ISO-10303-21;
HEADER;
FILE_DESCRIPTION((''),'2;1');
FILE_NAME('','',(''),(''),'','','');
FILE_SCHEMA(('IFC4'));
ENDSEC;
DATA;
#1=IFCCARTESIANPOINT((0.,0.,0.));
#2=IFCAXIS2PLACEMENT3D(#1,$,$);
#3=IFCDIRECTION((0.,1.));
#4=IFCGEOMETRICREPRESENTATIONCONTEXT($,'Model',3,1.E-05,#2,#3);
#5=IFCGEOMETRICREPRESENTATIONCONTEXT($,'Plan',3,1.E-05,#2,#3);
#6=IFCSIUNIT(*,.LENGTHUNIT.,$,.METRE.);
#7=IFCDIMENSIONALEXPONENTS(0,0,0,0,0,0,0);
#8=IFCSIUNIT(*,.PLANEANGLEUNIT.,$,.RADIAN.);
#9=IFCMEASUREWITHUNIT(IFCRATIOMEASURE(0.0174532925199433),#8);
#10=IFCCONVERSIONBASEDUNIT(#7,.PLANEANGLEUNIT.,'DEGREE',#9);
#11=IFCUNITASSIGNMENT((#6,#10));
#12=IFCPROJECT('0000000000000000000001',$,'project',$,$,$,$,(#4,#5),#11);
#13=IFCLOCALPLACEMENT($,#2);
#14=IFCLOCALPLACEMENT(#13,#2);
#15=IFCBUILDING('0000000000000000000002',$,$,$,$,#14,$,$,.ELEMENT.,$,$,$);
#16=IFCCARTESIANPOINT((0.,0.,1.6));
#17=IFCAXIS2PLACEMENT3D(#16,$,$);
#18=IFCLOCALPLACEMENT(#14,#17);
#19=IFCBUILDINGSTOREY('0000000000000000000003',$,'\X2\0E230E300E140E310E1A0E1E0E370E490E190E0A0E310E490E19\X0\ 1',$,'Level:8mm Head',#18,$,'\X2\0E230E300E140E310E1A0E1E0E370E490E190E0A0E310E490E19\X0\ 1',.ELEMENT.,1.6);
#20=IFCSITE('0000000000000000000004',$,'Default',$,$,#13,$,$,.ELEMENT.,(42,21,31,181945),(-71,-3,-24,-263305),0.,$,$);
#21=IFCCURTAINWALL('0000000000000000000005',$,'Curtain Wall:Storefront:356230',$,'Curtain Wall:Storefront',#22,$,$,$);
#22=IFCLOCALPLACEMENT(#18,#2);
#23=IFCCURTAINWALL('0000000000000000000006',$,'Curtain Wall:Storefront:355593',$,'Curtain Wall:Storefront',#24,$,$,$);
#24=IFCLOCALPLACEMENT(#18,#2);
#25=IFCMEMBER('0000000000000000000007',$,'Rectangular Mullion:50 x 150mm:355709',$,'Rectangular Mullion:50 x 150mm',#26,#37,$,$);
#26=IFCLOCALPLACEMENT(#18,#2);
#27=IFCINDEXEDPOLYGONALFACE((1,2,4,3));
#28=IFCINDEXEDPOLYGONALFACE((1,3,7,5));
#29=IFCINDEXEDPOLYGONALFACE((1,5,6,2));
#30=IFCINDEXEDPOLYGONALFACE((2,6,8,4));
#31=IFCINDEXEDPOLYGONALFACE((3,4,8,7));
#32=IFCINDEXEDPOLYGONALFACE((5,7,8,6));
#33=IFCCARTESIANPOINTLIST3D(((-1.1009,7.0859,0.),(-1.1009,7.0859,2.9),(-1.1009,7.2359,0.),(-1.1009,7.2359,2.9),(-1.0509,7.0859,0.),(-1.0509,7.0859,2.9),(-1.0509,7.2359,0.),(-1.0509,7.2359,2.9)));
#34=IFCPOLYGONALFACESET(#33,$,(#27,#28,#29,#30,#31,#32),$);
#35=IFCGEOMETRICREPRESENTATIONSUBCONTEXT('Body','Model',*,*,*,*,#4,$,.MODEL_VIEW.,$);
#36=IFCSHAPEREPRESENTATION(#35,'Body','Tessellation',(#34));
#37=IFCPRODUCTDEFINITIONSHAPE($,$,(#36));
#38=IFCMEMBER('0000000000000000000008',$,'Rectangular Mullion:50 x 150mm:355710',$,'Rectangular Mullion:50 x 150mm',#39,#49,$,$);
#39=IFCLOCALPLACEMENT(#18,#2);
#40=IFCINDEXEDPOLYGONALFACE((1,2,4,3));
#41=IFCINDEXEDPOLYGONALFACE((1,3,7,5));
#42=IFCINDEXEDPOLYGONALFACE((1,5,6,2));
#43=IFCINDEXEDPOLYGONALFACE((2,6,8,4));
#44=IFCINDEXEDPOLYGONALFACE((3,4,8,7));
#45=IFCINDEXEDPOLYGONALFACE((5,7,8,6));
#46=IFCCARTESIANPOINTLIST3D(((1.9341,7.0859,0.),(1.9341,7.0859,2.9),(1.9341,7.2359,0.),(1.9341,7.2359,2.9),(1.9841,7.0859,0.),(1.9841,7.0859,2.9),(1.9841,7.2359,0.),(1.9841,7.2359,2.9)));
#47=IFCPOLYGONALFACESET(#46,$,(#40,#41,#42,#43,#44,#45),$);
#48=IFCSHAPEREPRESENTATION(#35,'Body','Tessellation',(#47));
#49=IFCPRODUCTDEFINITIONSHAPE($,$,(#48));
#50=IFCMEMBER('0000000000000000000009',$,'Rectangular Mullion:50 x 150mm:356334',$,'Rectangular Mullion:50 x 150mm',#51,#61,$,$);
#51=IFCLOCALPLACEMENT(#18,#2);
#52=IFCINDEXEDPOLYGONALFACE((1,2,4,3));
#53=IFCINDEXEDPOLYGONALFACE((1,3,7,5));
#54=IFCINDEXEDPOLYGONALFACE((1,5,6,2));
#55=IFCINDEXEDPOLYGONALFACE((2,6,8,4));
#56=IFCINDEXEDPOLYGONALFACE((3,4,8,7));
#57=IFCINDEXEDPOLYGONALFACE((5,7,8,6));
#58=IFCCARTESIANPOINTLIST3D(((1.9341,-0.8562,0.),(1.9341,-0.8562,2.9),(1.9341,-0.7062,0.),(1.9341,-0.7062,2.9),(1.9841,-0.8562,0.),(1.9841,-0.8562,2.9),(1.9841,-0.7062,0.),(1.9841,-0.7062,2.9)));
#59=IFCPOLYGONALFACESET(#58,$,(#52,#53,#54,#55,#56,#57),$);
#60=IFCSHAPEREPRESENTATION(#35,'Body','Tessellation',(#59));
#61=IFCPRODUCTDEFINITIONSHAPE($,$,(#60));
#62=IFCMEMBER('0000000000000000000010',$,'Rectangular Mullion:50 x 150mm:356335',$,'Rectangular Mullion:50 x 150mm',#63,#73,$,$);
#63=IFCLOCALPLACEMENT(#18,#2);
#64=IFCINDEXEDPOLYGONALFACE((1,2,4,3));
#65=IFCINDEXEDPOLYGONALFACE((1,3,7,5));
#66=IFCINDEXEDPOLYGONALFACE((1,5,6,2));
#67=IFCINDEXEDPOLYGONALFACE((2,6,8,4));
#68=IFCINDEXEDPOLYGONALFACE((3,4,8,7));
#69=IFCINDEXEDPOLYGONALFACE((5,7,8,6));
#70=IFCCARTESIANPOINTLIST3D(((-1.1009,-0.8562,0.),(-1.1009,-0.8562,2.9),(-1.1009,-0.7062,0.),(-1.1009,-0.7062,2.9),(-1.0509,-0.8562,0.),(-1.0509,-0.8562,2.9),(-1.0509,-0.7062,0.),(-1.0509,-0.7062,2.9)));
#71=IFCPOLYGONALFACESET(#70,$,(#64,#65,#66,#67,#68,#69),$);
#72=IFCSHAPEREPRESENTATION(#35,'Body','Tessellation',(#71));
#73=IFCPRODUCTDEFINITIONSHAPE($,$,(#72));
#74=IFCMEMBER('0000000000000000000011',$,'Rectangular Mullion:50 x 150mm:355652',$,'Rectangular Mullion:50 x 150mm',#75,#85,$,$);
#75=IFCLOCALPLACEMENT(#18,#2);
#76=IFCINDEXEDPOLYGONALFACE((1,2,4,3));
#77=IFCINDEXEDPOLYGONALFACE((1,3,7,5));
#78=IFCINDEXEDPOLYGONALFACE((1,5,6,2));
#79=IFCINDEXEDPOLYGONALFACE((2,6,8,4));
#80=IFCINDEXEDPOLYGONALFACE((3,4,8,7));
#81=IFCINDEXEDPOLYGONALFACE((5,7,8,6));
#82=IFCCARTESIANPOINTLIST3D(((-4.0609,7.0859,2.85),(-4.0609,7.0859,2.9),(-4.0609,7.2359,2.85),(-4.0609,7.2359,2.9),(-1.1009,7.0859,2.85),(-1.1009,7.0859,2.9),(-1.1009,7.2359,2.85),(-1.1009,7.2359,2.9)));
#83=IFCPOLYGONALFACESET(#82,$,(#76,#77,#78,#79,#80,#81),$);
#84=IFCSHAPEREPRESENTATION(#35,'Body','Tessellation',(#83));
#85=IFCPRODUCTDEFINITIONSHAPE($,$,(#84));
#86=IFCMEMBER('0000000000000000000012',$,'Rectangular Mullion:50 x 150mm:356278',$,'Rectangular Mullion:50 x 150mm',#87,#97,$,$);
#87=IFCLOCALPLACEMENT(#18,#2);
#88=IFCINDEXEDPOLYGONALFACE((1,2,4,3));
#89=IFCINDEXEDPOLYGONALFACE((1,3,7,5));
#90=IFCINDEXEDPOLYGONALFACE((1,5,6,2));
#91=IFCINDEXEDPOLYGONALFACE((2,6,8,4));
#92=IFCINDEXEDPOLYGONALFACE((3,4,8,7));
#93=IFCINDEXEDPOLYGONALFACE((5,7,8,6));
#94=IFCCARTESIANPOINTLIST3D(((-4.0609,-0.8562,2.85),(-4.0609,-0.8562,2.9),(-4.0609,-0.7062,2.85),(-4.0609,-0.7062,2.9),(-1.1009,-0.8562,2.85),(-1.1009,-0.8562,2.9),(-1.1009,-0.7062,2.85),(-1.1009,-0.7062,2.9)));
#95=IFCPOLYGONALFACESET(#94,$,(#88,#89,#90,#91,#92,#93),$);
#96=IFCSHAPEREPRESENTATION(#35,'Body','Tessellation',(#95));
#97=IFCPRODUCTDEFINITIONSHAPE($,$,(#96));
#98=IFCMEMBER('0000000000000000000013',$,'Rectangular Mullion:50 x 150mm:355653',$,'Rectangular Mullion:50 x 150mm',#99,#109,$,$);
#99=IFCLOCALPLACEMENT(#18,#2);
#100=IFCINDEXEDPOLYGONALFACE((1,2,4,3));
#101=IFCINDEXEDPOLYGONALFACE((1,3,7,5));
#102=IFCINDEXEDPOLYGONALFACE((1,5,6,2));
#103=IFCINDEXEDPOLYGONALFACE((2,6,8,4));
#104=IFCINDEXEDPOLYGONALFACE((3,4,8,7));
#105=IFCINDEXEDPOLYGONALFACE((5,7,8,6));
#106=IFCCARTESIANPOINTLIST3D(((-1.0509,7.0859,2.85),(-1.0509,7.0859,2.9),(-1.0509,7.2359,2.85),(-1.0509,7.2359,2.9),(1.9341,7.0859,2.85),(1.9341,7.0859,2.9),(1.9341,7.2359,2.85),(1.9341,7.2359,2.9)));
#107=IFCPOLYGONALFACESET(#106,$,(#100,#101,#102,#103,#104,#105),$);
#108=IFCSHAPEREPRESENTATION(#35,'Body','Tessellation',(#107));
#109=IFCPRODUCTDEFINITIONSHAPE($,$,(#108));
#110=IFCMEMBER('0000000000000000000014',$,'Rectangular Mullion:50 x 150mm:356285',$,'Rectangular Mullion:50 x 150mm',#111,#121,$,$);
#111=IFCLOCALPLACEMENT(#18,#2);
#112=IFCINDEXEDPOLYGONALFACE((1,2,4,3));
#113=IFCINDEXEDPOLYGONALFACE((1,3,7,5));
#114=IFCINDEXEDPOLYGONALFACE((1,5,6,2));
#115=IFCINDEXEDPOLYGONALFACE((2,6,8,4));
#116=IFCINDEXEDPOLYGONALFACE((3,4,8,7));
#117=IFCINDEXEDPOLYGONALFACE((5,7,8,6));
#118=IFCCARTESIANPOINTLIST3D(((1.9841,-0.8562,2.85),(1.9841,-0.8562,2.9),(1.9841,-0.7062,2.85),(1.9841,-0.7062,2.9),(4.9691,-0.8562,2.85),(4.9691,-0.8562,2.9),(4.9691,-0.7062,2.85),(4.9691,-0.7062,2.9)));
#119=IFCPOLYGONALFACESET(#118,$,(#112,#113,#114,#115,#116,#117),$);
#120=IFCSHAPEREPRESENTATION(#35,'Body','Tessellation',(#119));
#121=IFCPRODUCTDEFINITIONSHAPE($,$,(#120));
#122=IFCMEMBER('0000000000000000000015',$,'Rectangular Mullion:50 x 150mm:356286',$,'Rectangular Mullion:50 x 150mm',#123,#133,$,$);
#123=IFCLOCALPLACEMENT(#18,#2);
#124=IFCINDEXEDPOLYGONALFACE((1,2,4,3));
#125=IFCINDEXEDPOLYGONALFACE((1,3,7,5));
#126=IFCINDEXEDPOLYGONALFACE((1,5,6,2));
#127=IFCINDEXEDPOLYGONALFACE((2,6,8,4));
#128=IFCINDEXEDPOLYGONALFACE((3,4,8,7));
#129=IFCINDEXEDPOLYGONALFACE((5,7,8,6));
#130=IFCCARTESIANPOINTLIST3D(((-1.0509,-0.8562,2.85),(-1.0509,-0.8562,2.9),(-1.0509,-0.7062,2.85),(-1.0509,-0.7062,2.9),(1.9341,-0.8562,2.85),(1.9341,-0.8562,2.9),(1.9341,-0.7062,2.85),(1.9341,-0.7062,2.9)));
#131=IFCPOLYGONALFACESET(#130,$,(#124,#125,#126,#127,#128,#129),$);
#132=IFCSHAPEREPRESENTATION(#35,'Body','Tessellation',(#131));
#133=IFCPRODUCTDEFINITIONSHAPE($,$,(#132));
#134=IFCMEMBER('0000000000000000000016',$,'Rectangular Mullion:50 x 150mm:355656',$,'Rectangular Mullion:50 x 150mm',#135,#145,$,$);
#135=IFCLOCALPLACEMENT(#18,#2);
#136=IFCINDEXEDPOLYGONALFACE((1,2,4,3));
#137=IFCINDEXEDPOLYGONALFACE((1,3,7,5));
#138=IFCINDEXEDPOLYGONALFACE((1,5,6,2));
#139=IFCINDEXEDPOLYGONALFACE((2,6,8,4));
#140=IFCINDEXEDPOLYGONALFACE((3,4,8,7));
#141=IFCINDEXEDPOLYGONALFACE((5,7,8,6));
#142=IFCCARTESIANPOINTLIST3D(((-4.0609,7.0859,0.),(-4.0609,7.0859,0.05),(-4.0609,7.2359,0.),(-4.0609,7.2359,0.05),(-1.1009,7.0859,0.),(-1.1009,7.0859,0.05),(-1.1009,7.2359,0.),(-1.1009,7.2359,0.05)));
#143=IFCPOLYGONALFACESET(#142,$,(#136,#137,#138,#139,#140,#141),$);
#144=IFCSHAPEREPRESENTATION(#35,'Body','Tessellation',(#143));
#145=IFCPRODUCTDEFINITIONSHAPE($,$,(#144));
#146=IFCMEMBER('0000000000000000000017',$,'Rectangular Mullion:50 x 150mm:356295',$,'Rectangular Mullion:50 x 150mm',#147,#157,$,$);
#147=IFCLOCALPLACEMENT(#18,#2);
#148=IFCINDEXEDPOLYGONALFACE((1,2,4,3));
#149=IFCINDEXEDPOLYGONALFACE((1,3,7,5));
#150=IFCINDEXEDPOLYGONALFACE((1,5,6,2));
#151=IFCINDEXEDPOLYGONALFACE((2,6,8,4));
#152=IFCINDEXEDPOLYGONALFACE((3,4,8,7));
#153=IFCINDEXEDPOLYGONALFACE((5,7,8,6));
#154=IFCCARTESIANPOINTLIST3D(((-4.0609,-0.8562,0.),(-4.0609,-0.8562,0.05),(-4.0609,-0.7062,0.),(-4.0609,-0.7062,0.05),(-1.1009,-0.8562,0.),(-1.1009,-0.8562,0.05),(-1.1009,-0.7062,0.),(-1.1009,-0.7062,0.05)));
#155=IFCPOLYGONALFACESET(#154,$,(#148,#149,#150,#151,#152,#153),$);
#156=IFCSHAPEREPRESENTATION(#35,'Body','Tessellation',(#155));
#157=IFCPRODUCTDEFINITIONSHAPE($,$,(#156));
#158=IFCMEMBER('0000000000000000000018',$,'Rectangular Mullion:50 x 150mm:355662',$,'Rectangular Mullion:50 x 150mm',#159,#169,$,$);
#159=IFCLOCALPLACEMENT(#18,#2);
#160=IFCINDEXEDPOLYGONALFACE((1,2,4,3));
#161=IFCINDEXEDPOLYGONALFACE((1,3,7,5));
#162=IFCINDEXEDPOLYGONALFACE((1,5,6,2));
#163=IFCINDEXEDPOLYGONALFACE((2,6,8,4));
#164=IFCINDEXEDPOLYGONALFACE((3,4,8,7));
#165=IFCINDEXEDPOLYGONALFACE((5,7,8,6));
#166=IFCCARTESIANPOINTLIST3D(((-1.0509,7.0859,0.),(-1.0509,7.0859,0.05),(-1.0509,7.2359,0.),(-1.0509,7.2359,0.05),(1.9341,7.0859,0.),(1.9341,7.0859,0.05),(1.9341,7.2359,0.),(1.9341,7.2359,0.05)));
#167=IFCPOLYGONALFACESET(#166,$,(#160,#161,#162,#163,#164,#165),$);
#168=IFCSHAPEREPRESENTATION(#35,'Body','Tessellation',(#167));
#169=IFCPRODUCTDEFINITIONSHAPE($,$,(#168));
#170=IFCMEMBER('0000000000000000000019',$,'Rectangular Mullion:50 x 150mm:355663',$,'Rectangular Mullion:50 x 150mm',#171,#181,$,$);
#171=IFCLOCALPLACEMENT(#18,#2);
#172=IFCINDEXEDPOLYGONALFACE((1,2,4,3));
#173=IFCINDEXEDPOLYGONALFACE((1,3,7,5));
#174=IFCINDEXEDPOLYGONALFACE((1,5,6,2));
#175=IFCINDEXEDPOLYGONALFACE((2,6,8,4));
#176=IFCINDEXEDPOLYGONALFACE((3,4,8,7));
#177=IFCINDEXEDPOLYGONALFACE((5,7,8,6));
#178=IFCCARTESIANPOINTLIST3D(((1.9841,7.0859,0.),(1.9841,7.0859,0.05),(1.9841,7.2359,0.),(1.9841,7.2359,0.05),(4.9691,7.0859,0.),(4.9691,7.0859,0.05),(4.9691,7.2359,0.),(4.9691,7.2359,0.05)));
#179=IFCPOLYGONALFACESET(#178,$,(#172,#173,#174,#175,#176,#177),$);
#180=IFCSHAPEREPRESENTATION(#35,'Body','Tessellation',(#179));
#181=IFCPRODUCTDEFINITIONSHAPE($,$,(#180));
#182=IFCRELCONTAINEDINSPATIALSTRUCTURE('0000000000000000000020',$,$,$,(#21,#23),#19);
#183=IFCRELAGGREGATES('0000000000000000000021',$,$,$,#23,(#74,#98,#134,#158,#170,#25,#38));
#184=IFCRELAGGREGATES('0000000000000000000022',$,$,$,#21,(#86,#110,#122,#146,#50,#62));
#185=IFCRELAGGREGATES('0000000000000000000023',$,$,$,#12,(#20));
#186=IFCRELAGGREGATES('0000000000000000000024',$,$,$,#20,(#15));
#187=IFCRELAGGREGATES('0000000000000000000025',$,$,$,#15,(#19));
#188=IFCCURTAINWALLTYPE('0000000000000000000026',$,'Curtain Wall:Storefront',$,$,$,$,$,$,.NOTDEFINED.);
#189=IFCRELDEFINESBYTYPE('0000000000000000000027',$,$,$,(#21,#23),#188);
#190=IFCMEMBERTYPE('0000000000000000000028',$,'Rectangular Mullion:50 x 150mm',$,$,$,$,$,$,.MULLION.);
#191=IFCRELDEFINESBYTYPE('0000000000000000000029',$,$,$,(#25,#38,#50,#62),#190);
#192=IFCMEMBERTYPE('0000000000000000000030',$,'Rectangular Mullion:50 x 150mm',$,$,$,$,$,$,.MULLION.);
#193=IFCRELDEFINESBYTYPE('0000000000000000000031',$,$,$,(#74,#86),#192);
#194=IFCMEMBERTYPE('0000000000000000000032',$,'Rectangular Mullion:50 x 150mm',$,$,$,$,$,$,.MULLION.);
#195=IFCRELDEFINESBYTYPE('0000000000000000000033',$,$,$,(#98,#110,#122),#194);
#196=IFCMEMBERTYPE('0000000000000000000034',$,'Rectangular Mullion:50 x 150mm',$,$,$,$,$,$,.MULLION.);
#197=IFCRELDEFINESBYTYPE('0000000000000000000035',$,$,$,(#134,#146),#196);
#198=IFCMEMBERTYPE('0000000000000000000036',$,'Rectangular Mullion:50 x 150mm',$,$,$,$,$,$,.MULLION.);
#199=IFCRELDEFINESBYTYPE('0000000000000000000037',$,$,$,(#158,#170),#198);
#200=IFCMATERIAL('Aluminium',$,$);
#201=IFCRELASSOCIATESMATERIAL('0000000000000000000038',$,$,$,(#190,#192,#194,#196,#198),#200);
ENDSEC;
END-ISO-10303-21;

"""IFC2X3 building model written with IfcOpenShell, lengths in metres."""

from ifc_helpers import new_model, entity, si_unit, converted_unit, direction, frame, origin, origin_2d_with_axis, place, context, subcontext, project, spatial, rectangle, extrude, source, transform, mapped, material, type_object, type_shapes, element, aggregate, save


model = new_model("IFC2X3")

# Units and contexts
model_context = context("Model", 3, precision=1e-05, world=origin(), true_north=direction((0.0, 1.0)))
plan_context = context("Plan", 3, precision=1e-05, world=origin(), true_north=direction((0.0, 1.0)))
body_context = subcontext(model_context, "Body", "Model", "MODEL_VIEW")
ifc_project = project(units=[si_unit("LENGTHUNIT", "METRE"), converted_unit("PLANEANGLEUNIT", "DEGREE", entity("IfcRatioMeasure", 0.0174532925199433), si_unit("PLANEANGLEUNIT", "RADIAN"), dimensions=[0, 0, 0, 0, 0, 0, 0])], contexts=[model_context, plan_context])

# Site, building, storey
site_placement = place(None, origin())
site = spatial("IfcSite", under=ifc_project, at=site_placement, Name="Default", CompositionType="ELEMENT", RefLatitude=(42, 21, 31, 181945), RefLongitude=(-71, -3, -24, -263305), RefElevation=0.0)
building_placement = place(site_placement, origin())
building = spatial("IfcBuilding", under=site, at=building_placement, CompositionType="ELEMENT")
storey_placement = place(building_placement, frame((0.0, 0.0, 1.6)))
storey = spatial("IfcBuildingStorey", under=building, at=storey_placement, Name="ระดับพื้นชั้น 1", ObjectType="Level:8mm Head", LongName="ระดับพื้นชั้น 1", CompositionType="ELEMENT", Elevation=1.6)

# Shared definitions
curtain_wall_type = type_object("IfcCurtainWallType", Name="Curtain Wall:Storefront", PredefinedType="NOTDEFINED")
ifc_material_1 = material(Name="Aluminium")

# Curtain wall
curtain_wall_1_placement = place(storey_placement, frame((0.0, 0.0, -1.6)))
curtain_wall_1 = element("IfcCurtainWall", 1, at=curtain_wall_1_placement, inside=storey, type_object=curtain_wall_type, Name="Curtain Wall:Storefront:356230", ObjectType="Curtain Wall:Storefront")

# Curtain wall
curtain_wall_2_placement = place(storey_placement, frame((0.0, 0.0, -1.6)))
curtain_wall_2 = element("IfcCurtainWall", 2, at=curtain_wall_2_placement, inside=storey, type_object=curtain_wall_type, Name="Curtain Wall:Storefront:355593", ObjectType="Curtain Wall:Storefront")

# Members
member_type_1 = type_object("IfcMemberType", Name="Rectangular Mullion:50 x 150mm", PredefinedType="MULLION", material=ifc_material_1)
shared_shape_1 = source(origin(), body_context, "Body", "SweptSolid", [
    extrude(rectangle(XDim=0.15, YDim=0.05, at=origin_2d_with_axis()), frame((0.0, 0.0, -2.9), z_axis=(0.0, 0.0, 1.0), x_axis=(0.0, -1.0, 0.0)), (0.0, 0.0, 1.0), 2.9),
])
type_shapes(member_type_1, [shared_shape_1])
member_1_placement = place(curtain_wall_2_placement, frame((-1.0759, 7.1609, 1.6), z_axis=(0.0, 0.0, -1.0), x_axis=(1.0, 0.0, 0.0)))
member_1 = element("IfcMember", 3, at=member_1_placement, type_object=member_type_1, Name="Rectangular Mullion:50 x 150mm:355709", ObjectType="Rectangular Mullion:50 x 150mm", context=body_context, shape_type="MappedRepresentation", body=[
    mapped(shared_shape_1, transform((0.0, 0.0, 0.0), scale=1.0)),
])
member_2_placement = place(curtain_wall_2_placement, frame((1.9591, 7.1609, 1.6), z_axis=(0.0, 0.0, -1.0), x_axis=(1.0, 0.0, 0.0)))
member_2 = element("IfcMember", 4, at=member_2_placement, type_object=member_type_1, Name="Rectangular Mullion:50 x 150mm:355710", ObjectType="Rectangular Mullion:50 x 150mm", context=body_context, shape_type="MappedRepresentation", body=[
    mapped(shared_shape_1, transform((0.0, 0.0, 0.0), scale=1.0)),
])
member_3_placement = place(curtain_wall_1_placement, frame((1.9591, -0.7812, 1.6), z_axis=(0.0, 0.0, -1.0), x_axis=(-1.0, 0.0, 0.0)))
member_3 = element("IfcMember", 5, at=member_3_placement, type_object=member_type_1, Name="Rectangular Mullion:50 x 150mm:356334", ObjectType="Rectangular Mullion:50 x 150mm", context=body_context, shape_type="MappedRepresentation", body=[
    mapped(shared_shape_1, transform((0.0, 0.0, 0.0), scale=1.0)),
])
member_4_placement = place(curtain_wall_1_placement, frame((-1.0759, -0.7812, 1.6), z_axis=(0.0, 0.0, -1.0), x_axis=(-1.0, 0.0, 0.0)))
member_4 = element("IfcMember", 6, at=member_4_placement, type_object=member_type_1, Name="Rectangular Mullion:50 x 150mm:356335", ObjectType="Rectangular Mullion:50 x 150mm", context=body_context, shape_type="MappedRepresentation", body=[
    mapped(shared_shape_1, transform((0.0, 0.0, 0.0), scale=1.0)),
])
member_type_2 = type_object("IfcMemberType", Name="Rectangular Mullion:50 x 150mm", PredefinedType="MULLION", material=ifc_material_1)
shared_shape_2 = source(origin(), body_context, "Body", "SweptSolid", [
    extrude(rectangle(XDim=0.15, YDim=0.05, at=origin_2d_with_axis()), frame((-0.025, 0.0, -2.96), z_axis=(0.0, 0.0, 1.0), x_axis=(0.0, -1.0, 0.0)), (0.0, 0.0, 1.0), 2.96),
])
type_shapes(member_type_2, [shared_shape_2])
member_5_placement = place(curtain_wall_2_placement, frame((-1.1009, 7.1609, 4.5), z_axis=(1.0, 0.0, 0.0), x_axis=(0.0, 0.0, 1.0)))
member_5 = element("IfcMember", 7, at=member_5_placement, type_object=member_type_2, Name="Rectangular Mullion:50 x 150mm:355652", ObjectType="Rectangular Mullion:50 x 150mm", context=body_context, shape_type="MappedRepresentation", body=[
    mapped(shared_shape_2, transform((0.0, 0.0, 0.0), scale=1.0)),
])
member_6_placement = place(curtain_wall_1_placement, frame((-4.0609, -0.7812, 4.5), z_axis=(-1.0, 0.0, 0.0), x_axis=(0.0, 0.0, 1.0)))
member_6 = element("IfcMember", 8, at=member_6_placement, type_object=member_type_2, Name="Rectangular Mullion:50 x 150mm:356278", ObjectType="Rectangular Mullion:50 x 150mm", context=body_context, shape_type="MappedRepresentation", body=[
    mapped(shared_shape_2, transform((0.0, 0.0, 0.0), scale=1.0)),
])
member_type_3 = type_object("IfcMemberType", Name="Rectangular Mullion:50 x 150mm", PredefinedType="MULLION", material=ifc_material_1)
shared_shape_3 = source(origin(), body_context, "Body", "SweptSolid", [
    extrude(rectangle(XDim=0.15, YDim=0.05, at=origin_2d_with_axis()), frame((-0.025, 0.0, -2.985), z_axis=(0.0, 0.0, 1.0), x_axis=(0.0, -1.0, 0.0)), (0.0, 0.0, 1.0), 2.985),
])
type_shapes(member_type_3, [shared_shape_3])
member_7_placement = place(curtain_wall_2_placement, frame((1.9341, 7.1609, 4.5), z_axis=(1.0, 0.0, 0.0), x_axis=(0.0, 0.0, 1.0)))
member_7 = element("IfcMember", 9, at=member_7_placement, type_object=member_type_3, Name="Rectangular Mullion:50 x 150mm:355653", ObjectType="Rectangular Mullion:50 x 150mm", context=body_context, shape_type="MappedRepresentation", body=[
    mapped(shared_shape_3, transform((0.0, 0.0, 0.0), scale=1.0)),
])
member_8_placement = place(curtain_wall_1_placement, frame((1.9841, -0.7812, 4.5), z_axis=(-1.0, 0.0, 0.0), x_axis=(0.0, 0.0, 1.0)))
member_8 = element("IfcMember", 10, at=member_8_placement, type_object=member_type_3, Name="Rectangular Mullion:50 x 150mm:356285", ObjectType="Rectangular Mullion:50 x 150mm", context=body_context, shape_type="MappedRepresentation", body=[
    mapped(shared_shape_3, transform((0.0, 0.0, 0.0), scale=1.0)),
])
member_9_placement = place(curtain_wall_1_placement, frame((-1.0509, -0.7812, 4.5), z_axis=(-1.0, 0.0, 0.0), x_axis=(0.0, 0.0, 1.0)))
member_9 = element("IfcMember", 11, at=member_9_placement, type_object=member_type_3, Name="Rectangular Mullion:50 x 150mm:356286", ObjectType="Rectangular Mullion:50 x 150mm", context=body_context, shape_type="MappedRepresentation", body=[
    mapped(shared_shape_3, transform((0.0, 0.0, 0.0), scale=1.0)),
])
member_type_4 = type_object("IfcMemberType", Name="Rectangular Mullion:50 x 150mm", PredefinedType="MULLION", material=ifc_material_1)
shared_shape_4 = source(origin(), body_context, "Body", "SweptSolid", [
    extrude(rectangle(XDim=0.15, YDim=0.05, at=origin_2d_with_axis()), frame((-0.025, 0.0, -2.96), z_axis=(0.0, 0.0, 1.0), x_axis=(0.0, -1.0, 0.0)), (0.0, 0.0, 1.0), 2.96),
])
type_shapes(member_type_4, [shared_shape_4])
member_10_placement = place(curtain_wall_2_placement, frame((-4.0609, 7.1609, 1.6), z_axis=(-1.0, 0.0, 0.0), x_axis=(0.0, 0.0, -1.0)))
member_10 = element("IfcMember", 12, at=member_10_placement, type_object=member_type_4, Name="Rectangular Mullion:50 x 150mm:355656", ObjectType="Rectangular Mullion:50 x 150mm", context=body_context, shape_type="MappedRepresentation", body=[
    mapped(shared_shape_4, transform((0.0, 0.0, 0.0), scale=1.0)),
])
member_11_placement = place(curtain_wall_1_placement, frame((-1.1009, -0.7812, 1.6), z_axis=(1.0, 0.0, 0.0), x_axis=(0.0, 0.0, -1.0)))
member_11 = element("IfcMember", 13, at=member_11_placement, type_object=member_type_4, Name="Rectangular Mullion:50 x 150mm:356295", ObjectType="Rectangular Mullion:50 x 150mm", context=body_context, shape_type="MappedRepresentation", body=[
    mapped(shared_shape_4, transform((0.0, 0.0, 0.0), scale=1.0)),
])
member_type_5 = type_object("IfcMemberType", Name="Rectangular Mullion:50 x 150mm", PredefinedType="MULLION", material=ifc_material_1)
shared_shape_5 = source(origin(), body_context, "Body", "SweptSolid", [
    extrude(rectangle(XDim=0.15, YDim=0.05, at=origin_2d_with_axis()), frame((-0.025, 0.0, -2.985), z_axis=(0.0, 0.0, 1.0), x_axis=(0.0, -1.0, 0.0)), (0.0, 0.0, 1.0), 2.985),
])
type_shapes(member_type_5, [shared_shape_5])
member_12_placement = place(curtain_wall_2_placement, frame((-1.0509, 7.1609, 1.6), z_axis=(-1.0, 0.0, 0.0), x_axis=(0.0, 0.0, -1.0)))
member_12 = element("IfcMember", 14, at=member_12_placement, type_object=member_type_5, Name="Rectangular Mullion:50 x 150mm:355662", ObjectType="Rectangular Mullion:50 x 150mm", context=body_context, shape_type="MappedRepresentation", body=[
    mapped(shared_shape_5, transform((0.0, 0.0, 0.0), scale=1.0)),
])
member_13_placement = place(curtain_wall_2_placement, frame((1.9841, 7.1609, 1.6), z_axis=(-1.0, 0.0, 0.0), x_axis=(0.0, 0.0, -1.0)))
member_13 = element("IfcMember", 15, at=member_13_placement, type_object=member_type_5, Name="Rectangular Mullion:50 x 150mm:355663", ObjectType="Rectangular Mullion:50 x 150mm", context=body_context, shape_type="MappedRepresentation", body=[
    mapped(shared_shape_5, transform((0.0, 0.0, 0.0), scale=1.0)),
])

aggregate(curtain_wall_2, [member_5, member_7, member_10, member_12, member_13, member_1, member_2])
aggregate(curtain_wall_1, [member_6, member_8, member_9, member_11, member_3, member_4])

save(model, "model.ifc")
